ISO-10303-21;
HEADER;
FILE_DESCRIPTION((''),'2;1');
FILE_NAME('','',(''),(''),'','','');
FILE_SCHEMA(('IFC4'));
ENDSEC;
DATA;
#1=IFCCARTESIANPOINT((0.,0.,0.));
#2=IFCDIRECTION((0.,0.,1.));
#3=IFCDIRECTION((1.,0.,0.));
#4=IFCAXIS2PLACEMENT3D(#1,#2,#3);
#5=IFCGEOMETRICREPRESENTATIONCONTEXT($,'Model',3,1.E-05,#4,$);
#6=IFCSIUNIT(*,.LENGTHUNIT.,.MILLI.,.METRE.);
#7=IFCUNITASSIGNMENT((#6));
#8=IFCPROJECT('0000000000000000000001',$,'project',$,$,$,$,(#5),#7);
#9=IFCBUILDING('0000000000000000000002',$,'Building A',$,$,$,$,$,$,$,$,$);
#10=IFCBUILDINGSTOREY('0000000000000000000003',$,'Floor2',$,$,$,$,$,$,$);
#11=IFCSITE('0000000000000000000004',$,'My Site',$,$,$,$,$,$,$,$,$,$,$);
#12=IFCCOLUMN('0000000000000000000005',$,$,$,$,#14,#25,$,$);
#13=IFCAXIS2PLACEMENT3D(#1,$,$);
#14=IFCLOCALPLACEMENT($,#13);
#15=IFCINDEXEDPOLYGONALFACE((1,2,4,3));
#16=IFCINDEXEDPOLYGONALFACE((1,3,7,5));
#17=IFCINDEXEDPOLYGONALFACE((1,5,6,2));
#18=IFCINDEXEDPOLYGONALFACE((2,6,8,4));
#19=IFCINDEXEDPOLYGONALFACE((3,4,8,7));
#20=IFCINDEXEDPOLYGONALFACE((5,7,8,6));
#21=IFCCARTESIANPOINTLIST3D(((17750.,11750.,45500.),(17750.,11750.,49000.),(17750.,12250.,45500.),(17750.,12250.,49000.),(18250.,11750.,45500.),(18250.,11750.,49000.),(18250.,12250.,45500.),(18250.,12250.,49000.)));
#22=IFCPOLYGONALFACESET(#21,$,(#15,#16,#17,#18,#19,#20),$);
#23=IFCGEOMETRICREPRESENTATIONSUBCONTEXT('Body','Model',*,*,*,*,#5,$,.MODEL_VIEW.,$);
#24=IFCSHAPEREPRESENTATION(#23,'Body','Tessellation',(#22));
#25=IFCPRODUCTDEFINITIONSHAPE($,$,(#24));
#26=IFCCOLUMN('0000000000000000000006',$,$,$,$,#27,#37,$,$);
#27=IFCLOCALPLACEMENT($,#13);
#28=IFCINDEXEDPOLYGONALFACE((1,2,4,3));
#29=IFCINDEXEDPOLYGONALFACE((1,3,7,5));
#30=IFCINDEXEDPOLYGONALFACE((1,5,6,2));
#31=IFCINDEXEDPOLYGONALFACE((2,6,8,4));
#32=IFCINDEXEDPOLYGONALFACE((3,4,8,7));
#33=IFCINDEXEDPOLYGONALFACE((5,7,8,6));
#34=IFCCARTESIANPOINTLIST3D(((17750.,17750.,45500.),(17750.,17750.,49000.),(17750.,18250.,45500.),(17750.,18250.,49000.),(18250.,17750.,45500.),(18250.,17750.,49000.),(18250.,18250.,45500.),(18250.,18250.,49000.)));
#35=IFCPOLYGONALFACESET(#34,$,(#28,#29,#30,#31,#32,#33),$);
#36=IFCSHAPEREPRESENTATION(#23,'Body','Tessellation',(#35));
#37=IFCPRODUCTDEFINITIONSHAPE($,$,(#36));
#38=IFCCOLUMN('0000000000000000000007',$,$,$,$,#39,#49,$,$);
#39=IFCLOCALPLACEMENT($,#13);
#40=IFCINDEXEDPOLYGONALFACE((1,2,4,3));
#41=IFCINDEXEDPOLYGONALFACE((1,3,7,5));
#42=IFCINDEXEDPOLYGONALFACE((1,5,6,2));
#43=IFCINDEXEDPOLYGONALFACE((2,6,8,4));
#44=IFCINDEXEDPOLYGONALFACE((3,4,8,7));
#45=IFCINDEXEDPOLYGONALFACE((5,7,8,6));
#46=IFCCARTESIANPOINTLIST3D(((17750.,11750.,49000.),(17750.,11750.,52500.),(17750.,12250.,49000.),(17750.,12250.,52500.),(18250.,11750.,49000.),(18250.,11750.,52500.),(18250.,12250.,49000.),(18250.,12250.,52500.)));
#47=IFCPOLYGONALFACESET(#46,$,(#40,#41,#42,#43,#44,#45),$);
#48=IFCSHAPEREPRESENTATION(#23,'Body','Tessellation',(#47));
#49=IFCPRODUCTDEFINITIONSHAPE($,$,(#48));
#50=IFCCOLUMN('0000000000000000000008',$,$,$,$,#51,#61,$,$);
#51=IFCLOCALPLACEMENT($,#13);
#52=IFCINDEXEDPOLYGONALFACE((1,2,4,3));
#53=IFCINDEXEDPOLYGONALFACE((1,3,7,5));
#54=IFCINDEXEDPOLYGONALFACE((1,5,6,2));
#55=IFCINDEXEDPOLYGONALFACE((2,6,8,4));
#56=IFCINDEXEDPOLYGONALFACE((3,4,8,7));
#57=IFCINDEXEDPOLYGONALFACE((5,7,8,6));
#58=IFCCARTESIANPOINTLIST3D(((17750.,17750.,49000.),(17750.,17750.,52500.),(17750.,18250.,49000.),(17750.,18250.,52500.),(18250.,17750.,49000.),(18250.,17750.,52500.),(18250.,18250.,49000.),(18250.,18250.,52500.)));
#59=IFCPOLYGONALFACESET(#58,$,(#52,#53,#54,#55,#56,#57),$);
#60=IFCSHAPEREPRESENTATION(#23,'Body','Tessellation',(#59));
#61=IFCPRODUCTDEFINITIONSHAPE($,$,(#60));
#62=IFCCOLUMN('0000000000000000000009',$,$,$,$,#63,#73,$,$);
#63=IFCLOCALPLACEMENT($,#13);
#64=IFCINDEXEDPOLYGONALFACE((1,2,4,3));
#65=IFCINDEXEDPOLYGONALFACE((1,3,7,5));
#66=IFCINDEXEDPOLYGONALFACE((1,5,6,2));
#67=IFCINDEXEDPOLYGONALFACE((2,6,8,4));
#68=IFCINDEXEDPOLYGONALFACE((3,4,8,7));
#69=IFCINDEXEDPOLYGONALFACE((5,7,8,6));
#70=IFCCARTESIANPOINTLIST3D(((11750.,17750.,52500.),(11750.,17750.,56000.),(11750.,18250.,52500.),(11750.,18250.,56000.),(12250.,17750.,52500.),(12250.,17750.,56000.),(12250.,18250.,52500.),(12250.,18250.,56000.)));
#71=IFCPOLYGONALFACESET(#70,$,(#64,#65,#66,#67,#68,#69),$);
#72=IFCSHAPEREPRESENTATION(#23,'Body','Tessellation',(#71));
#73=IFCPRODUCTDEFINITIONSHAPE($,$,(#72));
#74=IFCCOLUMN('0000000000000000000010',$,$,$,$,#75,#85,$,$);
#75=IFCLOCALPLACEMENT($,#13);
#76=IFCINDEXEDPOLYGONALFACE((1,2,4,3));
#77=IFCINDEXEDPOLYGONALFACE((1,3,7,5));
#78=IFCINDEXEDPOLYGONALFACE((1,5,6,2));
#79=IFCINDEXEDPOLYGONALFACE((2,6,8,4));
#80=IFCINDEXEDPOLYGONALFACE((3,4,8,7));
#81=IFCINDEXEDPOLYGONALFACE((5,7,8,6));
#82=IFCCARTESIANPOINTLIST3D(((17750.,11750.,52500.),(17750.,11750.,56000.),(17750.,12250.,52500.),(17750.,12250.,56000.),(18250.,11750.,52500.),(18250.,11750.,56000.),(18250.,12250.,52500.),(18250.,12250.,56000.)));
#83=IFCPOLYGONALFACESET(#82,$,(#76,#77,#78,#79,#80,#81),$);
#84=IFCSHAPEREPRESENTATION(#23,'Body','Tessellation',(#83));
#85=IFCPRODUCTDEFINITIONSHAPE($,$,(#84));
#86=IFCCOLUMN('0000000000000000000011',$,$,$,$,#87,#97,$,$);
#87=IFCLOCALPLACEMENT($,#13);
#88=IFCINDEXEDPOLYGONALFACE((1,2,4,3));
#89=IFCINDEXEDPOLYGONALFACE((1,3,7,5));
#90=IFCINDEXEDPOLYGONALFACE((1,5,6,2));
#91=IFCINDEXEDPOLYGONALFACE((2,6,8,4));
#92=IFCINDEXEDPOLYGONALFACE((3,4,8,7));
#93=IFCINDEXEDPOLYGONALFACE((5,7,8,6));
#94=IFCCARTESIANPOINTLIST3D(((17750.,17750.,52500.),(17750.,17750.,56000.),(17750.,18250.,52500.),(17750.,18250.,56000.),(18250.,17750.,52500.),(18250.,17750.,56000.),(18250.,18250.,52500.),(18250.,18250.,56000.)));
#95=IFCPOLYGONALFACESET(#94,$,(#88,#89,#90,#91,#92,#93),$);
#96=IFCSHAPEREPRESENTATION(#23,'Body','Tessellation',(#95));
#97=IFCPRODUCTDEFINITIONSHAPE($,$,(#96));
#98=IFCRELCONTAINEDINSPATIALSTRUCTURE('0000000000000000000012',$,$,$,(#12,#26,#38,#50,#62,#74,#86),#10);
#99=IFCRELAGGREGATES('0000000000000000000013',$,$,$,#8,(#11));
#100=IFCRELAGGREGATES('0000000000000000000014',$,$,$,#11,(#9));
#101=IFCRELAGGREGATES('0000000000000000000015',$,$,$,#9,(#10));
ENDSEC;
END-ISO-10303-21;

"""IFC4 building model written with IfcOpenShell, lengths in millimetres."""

from ifc_helpers import new_model, si_unit, frame, origin_with_axes, place, context, subcontext, project, spatial, line, indexed_curve, outline, extrude, element, save


model = new_model("IFC4")

# Units and contexts
model_context = context("Model", 3, precision=1e-05, world=origin_with_axes())
body_context = subcontext(model_context, "Body", "Model", "MODEL_VIEW")
ifc_project = project(units=[si_unit("LENGTHUNIT", "METRE", prefix="MILLI")], contexts=[model_context])

# Site, building, storey
site = spatial("IfcSite", under=ifc_project, Name="My Site")
building = spatial("IfcBuilding", under=site, Name="Building A")
storey = spatial("IfcBuildingStorey", under=building, Name="Floor2")

# Columns
for number, where, z_axis, x_axis in (
    (1, (18000.0, 12000.0, 45500.0), (0.0, 0.0, 1.0), (1.0, 0.0, 0.0)),
    (2, (18000.0, 18000.0, 45500.0), (0.0, 0.0, 1.0), (1.0, 0.0, 0.0)),
    (3, (18000.0, 12000.0, 49000.0), (0.0, 0.0, 1.0), (1.0, 0.0, 0.0)),
    (4, (18000.0, 18000.0, 49000.0), (0.0, 0.0, 1.0), (1.0, 0.0, 0.0)),
    (5, (12000.0, 18000.0, 52500.0), (0.0, 0.0, 1.0), (1.0, 0.0, 0.0)),
    (6, (18000.0, 12000.0, 52500.0), (0.0, 0.0, 1.0), (1.0, 0.0, 0.0)),
    (7, (18000.0, 18000.0, 52500.0), (0.0, 0.0, 1.0), (1.0, 0.0, 0.0)),
):
    element("IfcColumn", number, at=place(None, frame(where, z_axis=z_axis, x_axis=x_axis)), inside=storey, context=body_context, shape_type="SweptSolid", body=[
        extrude(outline(indexed_curve([(-250.0, -250.0), (250.0, -250.0), (250.0, 250.0), (-250.0, 250.0)], segments=[line(1, 2, 3, 4, 1)])), origin_with_axes(), (0.0, 0.0, 1.0), 3500.0),
    ])

save(model, "model.ifc")
